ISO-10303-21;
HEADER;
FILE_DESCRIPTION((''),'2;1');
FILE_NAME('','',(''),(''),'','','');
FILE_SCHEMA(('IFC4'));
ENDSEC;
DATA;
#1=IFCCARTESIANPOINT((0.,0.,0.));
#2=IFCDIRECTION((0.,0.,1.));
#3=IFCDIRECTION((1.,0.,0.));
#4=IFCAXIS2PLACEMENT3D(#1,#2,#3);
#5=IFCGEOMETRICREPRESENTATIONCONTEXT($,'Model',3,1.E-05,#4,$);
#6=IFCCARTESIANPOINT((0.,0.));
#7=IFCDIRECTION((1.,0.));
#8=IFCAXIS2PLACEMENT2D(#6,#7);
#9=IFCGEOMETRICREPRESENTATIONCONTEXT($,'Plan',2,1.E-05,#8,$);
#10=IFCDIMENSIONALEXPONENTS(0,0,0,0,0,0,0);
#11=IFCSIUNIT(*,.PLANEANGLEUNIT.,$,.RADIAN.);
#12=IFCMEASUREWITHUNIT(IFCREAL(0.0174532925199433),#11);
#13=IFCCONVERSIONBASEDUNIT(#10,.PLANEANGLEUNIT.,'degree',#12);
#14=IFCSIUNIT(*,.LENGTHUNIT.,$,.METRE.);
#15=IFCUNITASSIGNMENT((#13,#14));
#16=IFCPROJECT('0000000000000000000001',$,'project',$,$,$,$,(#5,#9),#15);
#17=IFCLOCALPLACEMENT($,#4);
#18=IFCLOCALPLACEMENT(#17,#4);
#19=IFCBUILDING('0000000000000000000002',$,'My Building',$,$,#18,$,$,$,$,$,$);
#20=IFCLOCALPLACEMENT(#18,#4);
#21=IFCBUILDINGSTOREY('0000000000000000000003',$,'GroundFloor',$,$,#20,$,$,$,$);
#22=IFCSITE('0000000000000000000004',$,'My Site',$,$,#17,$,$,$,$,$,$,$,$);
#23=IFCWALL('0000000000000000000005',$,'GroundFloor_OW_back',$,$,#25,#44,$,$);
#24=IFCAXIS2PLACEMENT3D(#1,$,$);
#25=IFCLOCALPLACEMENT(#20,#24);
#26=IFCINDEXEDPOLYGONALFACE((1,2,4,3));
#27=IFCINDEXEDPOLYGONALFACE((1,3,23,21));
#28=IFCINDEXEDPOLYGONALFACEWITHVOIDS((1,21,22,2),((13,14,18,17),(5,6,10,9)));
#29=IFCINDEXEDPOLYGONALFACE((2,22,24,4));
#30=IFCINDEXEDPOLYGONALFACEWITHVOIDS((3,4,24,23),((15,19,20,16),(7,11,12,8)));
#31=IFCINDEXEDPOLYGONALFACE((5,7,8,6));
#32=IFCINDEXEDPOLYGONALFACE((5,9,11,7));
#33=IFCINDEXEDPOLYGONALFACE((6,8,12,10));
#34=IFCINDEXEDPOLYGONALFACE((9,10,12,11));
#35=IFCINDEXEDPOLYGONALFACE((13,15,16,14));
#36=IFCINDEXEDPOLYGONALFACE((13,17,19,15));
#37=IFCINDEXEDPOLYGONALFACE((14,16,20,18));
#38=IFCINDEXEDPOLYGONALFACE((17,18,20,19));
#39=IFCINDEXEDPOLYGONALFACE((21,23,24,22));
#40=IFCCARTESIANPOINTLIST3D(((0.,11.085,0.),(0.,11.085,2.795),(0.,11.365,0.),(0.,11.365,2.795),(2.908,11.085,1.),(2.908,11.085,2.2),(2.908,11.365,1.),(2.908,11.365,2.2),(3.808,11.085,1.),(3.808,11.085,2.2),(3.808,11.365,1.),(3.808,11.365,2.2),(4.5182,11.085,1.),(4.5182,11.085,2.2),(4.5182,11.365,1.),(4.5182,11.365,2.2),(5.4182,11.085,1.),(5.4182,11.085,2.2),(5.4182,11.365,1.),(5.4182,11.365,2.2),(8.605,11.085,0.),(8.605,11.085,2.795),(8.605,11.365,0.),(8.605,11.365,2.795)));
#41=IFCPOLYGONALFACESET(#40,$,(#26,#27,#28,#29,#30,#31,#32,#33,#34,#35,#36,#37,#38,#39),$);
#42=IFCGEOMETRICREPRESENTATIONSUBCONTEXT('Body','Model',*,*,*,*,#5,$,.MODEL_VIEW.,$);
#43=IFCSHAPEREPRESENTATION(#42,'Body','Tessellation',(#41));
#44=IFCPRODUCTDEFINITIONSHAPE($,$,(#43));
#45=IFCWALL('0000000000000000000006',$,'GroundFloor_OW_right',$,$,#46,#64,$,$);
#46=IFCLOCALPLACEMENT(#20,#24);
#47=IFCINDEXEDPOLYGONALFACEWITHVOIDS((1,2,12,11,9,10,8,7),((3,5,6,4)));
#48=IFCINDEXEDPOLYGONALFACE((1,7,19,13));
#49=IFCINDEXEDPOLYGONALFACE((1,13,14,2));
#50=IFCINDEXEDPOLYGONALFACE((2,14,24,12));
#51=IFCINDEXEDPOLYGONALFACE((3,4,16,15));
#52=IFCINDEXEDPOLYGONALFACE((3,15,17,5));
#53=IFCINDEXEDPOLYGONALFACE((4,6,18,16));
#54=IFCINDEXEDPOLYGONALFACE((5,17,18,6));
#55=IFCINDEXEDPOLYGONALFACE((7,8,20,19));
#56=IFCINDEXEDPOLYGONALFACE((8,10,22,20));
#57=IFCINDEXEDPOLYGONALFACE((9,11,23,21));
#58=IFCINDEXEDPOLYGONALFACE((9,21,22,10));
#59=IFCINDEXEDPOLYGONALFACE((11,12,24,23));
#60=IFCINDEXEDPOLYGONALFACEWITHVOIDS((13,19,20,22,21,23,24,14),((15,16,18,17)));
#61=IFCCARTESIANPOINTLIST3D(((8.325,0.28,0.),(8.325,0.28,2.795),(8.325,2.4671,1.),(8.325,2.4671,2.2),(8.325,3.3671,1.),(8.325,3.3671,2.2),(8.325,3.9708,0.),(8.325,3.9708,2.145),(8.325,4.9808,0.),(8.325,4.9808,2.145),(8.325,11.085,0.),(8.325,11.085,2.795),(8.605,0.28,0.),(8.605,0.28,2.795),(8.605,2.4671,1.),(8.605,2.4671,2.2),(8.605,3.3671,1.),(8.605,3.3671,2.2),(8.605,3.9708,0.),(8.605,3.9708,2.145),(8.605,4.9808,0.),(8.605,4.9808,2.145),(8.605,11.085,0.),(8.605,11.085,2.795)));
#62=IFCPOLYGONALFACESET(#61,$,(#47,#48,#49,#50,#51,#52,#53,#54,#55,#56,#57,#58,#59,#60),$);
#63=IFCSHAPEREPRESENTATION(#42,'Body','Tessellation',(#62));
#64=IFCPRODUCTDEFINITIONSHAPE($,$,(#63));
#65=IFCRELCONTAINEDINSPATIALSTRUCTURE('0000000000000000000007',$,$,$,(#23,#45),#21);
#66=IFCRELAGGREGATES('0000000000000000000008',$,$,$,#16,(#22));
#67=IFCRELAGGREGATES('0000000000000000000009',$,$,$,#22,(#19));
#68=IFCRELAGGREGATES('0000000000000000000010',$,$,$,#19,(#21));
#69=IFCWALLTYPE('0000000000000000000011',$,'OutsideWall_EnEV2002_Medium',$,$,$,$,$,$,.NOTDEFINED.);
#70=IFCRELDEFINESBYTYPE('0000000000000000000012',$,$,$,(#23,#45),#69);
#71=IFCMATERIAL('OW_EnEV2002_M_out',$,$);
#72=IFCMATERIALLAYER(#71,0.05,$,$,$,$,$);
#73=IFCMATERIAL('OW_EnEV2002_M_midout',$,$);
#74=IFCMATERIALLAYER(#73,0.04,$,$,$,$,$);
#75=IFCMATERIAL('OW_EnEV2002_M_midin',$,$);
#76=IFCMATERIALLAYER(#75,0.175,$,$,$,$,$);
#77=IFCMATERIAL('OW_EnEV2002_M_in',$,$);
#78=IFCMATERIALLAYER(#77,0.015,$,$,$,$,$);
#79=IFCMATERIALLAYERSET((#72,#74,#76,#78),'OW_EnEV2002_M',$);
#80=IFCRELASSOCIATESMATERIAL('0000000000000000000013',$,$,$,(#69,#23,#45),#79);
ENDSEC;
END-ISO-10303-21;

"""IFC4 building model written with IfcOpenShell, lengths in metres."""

from ifc_helpers import new_model, entity, si_unit, converted_unit, frame, origin_with_axes, origin_2d_with_axis, place, context, subcontext, project, spatial, line, indexed_curve, outline, extrude, source, transform, mapped, material, layer, layer_set, layer_usage, type_object, element, save


model = new_model("IFC4")

# Units and contexts
model_context = context("Model", 3, precision=1e-05, world=origin_with_axes())
plan_context = context("Plan", 2, precision=1e-05, world=origin_2d_with_axis())
body_context = subcontext(model_context, "Body", "Model", "MODEL_VIEW")
ifc_project = project(units=[converted_unit("PLANEANGLEUNIT", "degree", entity("IfcReal", 0.0174532925199433), si_unit("PLANEANGLEUNIT", "RADIAN"), dimensions=[0, 0, 0, 0, 0, 0, 0]), si_unit("LENGTHUNIT", "METRE")], contexts=[model_context, plan_context])

# Site, building, storey
site_placement = place(None, origin_with_axes())
site = spatial("IfcSite", under=ifc_project, at=site_placement, Name="My Site")
building_placement = place(site_placement, origin_with_axes())
building = spatial("IfcBuilding", under=site, at=building_placement, Name="My Building")
storey_placement = place(building_placement, origin_with_axes())
storey = spatial("IfcBuildingStorey", under=building, at=storey_placement, Name="GroundFloor")

# Shared definitions
shared_shape_1 = source(origin_with_axes(), body_context, "Body", "SweptSolid", [
    extrude(outline(indexed_curve([(0.0, 0.0), (1.01, 0.0), (1.01, 2.145), (0.0, 2.145)], segments=[line(1, 2, 3, 4, 1)])), frame((0.0, -0.1, 0.0), z_axis=(0.0, -1.0, 0.0), x_axis=(1.0, 0.0, 0.0)), (0.0, 0.0, -1.0), 0.48),
])

# Walls, openings
ifc_material_1 = material(Name="OW_EnEV2002_M_out")
ifc_layer_1 = layer(ifc_material_1, 0.05)
ifc_material_2 = material(Name="OW_EnEV2002_M_midout")
ifc_layer_2 = layer(ifc_material_2, 0.04)
ifc_material_3 = material(Name="OW_EnEV2002_M_midin")
ifc_layer_3 = layer(ifc_material_3, 0.175)
ifc_material_4 = material(Name="OW_EnEV2002_M_in")
ifc_layer_4 = layer(ifc_material_4, 0.015)
ifc_layer_set_1 = layer_set([ifc_layer_1, ifc_layer_2, ifc_layer_3, ifc_layer_4], Name="OW_EnEV2002_M")
wall_type_1 = type_object("IfcWallType", Name="OutsideWall_EnEV2002_Medium", PredefinedType="NOTDEFINED", material=ifc_layer_set_1)
shared_shape_2 = source(origin_with_axes(), body_context, "Body", "SweptSolid", [
    extrude(outline(indexed_curve([(0.0, 0.0), (0.9, 0.0), (0.9, 1.2), (0.0, 1.2)], segments=[line(1, 2, 3, 4, 1)])), frame((0.0, -0.1, 0.0), z_axis=(0.0, -1.0, 0.0), x_axis=(1.0, 0.0, 0.0)), (0.0, 0.0, -1.0), 0.48),
])
ifc_layer_usage_1 = layer_usage(ifc_layer_set_1, "AXIS2", "POSITIVE", 0.0)
wall_1_placement = place(storey_placement, frame((8.605, 11.365, 0.0), z_axis=(0.0, 0.0, 1.0), x_axis=(-1.0, 0.0, 0.0)))
wall_1 = element("IfcWall", 1, at=wall_1_placement, inside=storey, type_object=wall_type_1, material=ifc_layer_usage_1, Name="GroundFloor_OW_back", context=body_context, shape_type="SweptSolid", body=[
    extrude(outline(indexed_curve([(0.0, 0.0), (0.0, 0.28), (8.605, 0.28), (8.605, 0.0), (0.0, 0.0)], self_intersect=False)), origin_with_axes(), (0.0, 0.0, 1.0), 2.795),
])
opening_1_placement = place(wall_1_placement, frame((4.797, 0.0, 1.0), z_axis=(0.0, 0.0, 1.0), x_axis=(1.0, 0.0, 0.0)))
element("IfcOpeningElement", 2, at=opening_1_placement, cuts=wall_1, PredefinedType="OPENING", context=body_context, shape_type="MappedRepresentation", body=[
    mapped(shared_shape_2, transform((0.0, 0.0, 0.0), x_axis=(1.0, 0.0, 0.0), y_axis=(0.0, 1.0, 0.0), z_axis=(0.0, 0.0, 1.0), scale=1.0)),
])
opening_2_placement = place(wall_1_placement, frame((3.1868, 0.0, 1.0), z_axis=(0.0, 0.0, 1.0), x_axis=(1.0, 0.0, 0.0)))
element("IfcOpeningElement", 3, at=opening_2_placement, cuts=wall_1, PredefinedType="OPENING", context=body_context, shape_type="MappedRepresentation", body=[
    mapped(shared_shape_2, transform((0.0, 0.0, 0.0), x_axis=(1.0, 0.0, 0.0), y_axis=(0.0, 1.0, 0.0), z_axis=(0.0, 0.0, 1.0), scale=1.0)),
])
ifc_layer_usage_2 = layer_usage(ifc_layer_set_1, "AXIS2", "POSITIVE", 0.0)
wall_2_placement = place(storey_placement, frame((8.605, 0.28, 0.0), z_axis=(0.0, 0.0, 1.0), x_axis=(0.0, 1.0, 0.0)))
wall_2 = element("IfcWall", 4, at=wall_2_placement, inside=storey, type_object=wall_type_1, material=ifc_layer_usage_2, Name="GroundFloor_OW_right", context=body_context, shape_type="SweptSolid", body=[
    extrude(outline(indexed_curve([(0.0, 0.0), (0.0, 0.28), (10.805, 0.28), (10.805, 0.0), (0.0, 0.0)], self_intersect=False)), origin_with_axes(), (0.0, 0.0, 1.0), 2.795),
])
opening_3_placement = place(wall_2_placement, frame((3.6908, 0.0, 0.0), z_axis=(0.0, 0.0, 1.0), x_axis=(1.0, 0.0, 0.0)))
element("IfcOpeningElement", 5, at=opening_3_placement, cuts=wall_2, PredefinedType="OPENING", context=body_context, shape_type="MappedRepresentation", body=[
    mapped(shared_shape_1, transform((0.0, 0.0, 0.0), x_axis=(1.0, 0.0, 0.0), y_axis=(0.0, 1.0, 0.0), z_axis=(0.0, 0.0, 1.0), scale=1.0)),
])
opening_4_placement = place(wall_2_placement, frame((2.1871, 0.0, 1.0), z_axis=(0.0, 0.0, 1.0), x_axis=(1.0, 0.0, 0.0)))
element("IfcOpeningElement", 6, at=opening_4_placement, cuts=wall_2, PredefinedType="OPENING", context=body_context, shape_type="MappedRepresentation", body=[
    mapped(shared_shape_2, transform((0.0, 0.0, 0.0), x_axis=(1.0, 0.0, 0.0), y_axis=(0.0, 1.0, 0.0), z_axis=(0.0, 0.0, 1.0), scale=1.0)),
])

save(model, "model.ifc")
